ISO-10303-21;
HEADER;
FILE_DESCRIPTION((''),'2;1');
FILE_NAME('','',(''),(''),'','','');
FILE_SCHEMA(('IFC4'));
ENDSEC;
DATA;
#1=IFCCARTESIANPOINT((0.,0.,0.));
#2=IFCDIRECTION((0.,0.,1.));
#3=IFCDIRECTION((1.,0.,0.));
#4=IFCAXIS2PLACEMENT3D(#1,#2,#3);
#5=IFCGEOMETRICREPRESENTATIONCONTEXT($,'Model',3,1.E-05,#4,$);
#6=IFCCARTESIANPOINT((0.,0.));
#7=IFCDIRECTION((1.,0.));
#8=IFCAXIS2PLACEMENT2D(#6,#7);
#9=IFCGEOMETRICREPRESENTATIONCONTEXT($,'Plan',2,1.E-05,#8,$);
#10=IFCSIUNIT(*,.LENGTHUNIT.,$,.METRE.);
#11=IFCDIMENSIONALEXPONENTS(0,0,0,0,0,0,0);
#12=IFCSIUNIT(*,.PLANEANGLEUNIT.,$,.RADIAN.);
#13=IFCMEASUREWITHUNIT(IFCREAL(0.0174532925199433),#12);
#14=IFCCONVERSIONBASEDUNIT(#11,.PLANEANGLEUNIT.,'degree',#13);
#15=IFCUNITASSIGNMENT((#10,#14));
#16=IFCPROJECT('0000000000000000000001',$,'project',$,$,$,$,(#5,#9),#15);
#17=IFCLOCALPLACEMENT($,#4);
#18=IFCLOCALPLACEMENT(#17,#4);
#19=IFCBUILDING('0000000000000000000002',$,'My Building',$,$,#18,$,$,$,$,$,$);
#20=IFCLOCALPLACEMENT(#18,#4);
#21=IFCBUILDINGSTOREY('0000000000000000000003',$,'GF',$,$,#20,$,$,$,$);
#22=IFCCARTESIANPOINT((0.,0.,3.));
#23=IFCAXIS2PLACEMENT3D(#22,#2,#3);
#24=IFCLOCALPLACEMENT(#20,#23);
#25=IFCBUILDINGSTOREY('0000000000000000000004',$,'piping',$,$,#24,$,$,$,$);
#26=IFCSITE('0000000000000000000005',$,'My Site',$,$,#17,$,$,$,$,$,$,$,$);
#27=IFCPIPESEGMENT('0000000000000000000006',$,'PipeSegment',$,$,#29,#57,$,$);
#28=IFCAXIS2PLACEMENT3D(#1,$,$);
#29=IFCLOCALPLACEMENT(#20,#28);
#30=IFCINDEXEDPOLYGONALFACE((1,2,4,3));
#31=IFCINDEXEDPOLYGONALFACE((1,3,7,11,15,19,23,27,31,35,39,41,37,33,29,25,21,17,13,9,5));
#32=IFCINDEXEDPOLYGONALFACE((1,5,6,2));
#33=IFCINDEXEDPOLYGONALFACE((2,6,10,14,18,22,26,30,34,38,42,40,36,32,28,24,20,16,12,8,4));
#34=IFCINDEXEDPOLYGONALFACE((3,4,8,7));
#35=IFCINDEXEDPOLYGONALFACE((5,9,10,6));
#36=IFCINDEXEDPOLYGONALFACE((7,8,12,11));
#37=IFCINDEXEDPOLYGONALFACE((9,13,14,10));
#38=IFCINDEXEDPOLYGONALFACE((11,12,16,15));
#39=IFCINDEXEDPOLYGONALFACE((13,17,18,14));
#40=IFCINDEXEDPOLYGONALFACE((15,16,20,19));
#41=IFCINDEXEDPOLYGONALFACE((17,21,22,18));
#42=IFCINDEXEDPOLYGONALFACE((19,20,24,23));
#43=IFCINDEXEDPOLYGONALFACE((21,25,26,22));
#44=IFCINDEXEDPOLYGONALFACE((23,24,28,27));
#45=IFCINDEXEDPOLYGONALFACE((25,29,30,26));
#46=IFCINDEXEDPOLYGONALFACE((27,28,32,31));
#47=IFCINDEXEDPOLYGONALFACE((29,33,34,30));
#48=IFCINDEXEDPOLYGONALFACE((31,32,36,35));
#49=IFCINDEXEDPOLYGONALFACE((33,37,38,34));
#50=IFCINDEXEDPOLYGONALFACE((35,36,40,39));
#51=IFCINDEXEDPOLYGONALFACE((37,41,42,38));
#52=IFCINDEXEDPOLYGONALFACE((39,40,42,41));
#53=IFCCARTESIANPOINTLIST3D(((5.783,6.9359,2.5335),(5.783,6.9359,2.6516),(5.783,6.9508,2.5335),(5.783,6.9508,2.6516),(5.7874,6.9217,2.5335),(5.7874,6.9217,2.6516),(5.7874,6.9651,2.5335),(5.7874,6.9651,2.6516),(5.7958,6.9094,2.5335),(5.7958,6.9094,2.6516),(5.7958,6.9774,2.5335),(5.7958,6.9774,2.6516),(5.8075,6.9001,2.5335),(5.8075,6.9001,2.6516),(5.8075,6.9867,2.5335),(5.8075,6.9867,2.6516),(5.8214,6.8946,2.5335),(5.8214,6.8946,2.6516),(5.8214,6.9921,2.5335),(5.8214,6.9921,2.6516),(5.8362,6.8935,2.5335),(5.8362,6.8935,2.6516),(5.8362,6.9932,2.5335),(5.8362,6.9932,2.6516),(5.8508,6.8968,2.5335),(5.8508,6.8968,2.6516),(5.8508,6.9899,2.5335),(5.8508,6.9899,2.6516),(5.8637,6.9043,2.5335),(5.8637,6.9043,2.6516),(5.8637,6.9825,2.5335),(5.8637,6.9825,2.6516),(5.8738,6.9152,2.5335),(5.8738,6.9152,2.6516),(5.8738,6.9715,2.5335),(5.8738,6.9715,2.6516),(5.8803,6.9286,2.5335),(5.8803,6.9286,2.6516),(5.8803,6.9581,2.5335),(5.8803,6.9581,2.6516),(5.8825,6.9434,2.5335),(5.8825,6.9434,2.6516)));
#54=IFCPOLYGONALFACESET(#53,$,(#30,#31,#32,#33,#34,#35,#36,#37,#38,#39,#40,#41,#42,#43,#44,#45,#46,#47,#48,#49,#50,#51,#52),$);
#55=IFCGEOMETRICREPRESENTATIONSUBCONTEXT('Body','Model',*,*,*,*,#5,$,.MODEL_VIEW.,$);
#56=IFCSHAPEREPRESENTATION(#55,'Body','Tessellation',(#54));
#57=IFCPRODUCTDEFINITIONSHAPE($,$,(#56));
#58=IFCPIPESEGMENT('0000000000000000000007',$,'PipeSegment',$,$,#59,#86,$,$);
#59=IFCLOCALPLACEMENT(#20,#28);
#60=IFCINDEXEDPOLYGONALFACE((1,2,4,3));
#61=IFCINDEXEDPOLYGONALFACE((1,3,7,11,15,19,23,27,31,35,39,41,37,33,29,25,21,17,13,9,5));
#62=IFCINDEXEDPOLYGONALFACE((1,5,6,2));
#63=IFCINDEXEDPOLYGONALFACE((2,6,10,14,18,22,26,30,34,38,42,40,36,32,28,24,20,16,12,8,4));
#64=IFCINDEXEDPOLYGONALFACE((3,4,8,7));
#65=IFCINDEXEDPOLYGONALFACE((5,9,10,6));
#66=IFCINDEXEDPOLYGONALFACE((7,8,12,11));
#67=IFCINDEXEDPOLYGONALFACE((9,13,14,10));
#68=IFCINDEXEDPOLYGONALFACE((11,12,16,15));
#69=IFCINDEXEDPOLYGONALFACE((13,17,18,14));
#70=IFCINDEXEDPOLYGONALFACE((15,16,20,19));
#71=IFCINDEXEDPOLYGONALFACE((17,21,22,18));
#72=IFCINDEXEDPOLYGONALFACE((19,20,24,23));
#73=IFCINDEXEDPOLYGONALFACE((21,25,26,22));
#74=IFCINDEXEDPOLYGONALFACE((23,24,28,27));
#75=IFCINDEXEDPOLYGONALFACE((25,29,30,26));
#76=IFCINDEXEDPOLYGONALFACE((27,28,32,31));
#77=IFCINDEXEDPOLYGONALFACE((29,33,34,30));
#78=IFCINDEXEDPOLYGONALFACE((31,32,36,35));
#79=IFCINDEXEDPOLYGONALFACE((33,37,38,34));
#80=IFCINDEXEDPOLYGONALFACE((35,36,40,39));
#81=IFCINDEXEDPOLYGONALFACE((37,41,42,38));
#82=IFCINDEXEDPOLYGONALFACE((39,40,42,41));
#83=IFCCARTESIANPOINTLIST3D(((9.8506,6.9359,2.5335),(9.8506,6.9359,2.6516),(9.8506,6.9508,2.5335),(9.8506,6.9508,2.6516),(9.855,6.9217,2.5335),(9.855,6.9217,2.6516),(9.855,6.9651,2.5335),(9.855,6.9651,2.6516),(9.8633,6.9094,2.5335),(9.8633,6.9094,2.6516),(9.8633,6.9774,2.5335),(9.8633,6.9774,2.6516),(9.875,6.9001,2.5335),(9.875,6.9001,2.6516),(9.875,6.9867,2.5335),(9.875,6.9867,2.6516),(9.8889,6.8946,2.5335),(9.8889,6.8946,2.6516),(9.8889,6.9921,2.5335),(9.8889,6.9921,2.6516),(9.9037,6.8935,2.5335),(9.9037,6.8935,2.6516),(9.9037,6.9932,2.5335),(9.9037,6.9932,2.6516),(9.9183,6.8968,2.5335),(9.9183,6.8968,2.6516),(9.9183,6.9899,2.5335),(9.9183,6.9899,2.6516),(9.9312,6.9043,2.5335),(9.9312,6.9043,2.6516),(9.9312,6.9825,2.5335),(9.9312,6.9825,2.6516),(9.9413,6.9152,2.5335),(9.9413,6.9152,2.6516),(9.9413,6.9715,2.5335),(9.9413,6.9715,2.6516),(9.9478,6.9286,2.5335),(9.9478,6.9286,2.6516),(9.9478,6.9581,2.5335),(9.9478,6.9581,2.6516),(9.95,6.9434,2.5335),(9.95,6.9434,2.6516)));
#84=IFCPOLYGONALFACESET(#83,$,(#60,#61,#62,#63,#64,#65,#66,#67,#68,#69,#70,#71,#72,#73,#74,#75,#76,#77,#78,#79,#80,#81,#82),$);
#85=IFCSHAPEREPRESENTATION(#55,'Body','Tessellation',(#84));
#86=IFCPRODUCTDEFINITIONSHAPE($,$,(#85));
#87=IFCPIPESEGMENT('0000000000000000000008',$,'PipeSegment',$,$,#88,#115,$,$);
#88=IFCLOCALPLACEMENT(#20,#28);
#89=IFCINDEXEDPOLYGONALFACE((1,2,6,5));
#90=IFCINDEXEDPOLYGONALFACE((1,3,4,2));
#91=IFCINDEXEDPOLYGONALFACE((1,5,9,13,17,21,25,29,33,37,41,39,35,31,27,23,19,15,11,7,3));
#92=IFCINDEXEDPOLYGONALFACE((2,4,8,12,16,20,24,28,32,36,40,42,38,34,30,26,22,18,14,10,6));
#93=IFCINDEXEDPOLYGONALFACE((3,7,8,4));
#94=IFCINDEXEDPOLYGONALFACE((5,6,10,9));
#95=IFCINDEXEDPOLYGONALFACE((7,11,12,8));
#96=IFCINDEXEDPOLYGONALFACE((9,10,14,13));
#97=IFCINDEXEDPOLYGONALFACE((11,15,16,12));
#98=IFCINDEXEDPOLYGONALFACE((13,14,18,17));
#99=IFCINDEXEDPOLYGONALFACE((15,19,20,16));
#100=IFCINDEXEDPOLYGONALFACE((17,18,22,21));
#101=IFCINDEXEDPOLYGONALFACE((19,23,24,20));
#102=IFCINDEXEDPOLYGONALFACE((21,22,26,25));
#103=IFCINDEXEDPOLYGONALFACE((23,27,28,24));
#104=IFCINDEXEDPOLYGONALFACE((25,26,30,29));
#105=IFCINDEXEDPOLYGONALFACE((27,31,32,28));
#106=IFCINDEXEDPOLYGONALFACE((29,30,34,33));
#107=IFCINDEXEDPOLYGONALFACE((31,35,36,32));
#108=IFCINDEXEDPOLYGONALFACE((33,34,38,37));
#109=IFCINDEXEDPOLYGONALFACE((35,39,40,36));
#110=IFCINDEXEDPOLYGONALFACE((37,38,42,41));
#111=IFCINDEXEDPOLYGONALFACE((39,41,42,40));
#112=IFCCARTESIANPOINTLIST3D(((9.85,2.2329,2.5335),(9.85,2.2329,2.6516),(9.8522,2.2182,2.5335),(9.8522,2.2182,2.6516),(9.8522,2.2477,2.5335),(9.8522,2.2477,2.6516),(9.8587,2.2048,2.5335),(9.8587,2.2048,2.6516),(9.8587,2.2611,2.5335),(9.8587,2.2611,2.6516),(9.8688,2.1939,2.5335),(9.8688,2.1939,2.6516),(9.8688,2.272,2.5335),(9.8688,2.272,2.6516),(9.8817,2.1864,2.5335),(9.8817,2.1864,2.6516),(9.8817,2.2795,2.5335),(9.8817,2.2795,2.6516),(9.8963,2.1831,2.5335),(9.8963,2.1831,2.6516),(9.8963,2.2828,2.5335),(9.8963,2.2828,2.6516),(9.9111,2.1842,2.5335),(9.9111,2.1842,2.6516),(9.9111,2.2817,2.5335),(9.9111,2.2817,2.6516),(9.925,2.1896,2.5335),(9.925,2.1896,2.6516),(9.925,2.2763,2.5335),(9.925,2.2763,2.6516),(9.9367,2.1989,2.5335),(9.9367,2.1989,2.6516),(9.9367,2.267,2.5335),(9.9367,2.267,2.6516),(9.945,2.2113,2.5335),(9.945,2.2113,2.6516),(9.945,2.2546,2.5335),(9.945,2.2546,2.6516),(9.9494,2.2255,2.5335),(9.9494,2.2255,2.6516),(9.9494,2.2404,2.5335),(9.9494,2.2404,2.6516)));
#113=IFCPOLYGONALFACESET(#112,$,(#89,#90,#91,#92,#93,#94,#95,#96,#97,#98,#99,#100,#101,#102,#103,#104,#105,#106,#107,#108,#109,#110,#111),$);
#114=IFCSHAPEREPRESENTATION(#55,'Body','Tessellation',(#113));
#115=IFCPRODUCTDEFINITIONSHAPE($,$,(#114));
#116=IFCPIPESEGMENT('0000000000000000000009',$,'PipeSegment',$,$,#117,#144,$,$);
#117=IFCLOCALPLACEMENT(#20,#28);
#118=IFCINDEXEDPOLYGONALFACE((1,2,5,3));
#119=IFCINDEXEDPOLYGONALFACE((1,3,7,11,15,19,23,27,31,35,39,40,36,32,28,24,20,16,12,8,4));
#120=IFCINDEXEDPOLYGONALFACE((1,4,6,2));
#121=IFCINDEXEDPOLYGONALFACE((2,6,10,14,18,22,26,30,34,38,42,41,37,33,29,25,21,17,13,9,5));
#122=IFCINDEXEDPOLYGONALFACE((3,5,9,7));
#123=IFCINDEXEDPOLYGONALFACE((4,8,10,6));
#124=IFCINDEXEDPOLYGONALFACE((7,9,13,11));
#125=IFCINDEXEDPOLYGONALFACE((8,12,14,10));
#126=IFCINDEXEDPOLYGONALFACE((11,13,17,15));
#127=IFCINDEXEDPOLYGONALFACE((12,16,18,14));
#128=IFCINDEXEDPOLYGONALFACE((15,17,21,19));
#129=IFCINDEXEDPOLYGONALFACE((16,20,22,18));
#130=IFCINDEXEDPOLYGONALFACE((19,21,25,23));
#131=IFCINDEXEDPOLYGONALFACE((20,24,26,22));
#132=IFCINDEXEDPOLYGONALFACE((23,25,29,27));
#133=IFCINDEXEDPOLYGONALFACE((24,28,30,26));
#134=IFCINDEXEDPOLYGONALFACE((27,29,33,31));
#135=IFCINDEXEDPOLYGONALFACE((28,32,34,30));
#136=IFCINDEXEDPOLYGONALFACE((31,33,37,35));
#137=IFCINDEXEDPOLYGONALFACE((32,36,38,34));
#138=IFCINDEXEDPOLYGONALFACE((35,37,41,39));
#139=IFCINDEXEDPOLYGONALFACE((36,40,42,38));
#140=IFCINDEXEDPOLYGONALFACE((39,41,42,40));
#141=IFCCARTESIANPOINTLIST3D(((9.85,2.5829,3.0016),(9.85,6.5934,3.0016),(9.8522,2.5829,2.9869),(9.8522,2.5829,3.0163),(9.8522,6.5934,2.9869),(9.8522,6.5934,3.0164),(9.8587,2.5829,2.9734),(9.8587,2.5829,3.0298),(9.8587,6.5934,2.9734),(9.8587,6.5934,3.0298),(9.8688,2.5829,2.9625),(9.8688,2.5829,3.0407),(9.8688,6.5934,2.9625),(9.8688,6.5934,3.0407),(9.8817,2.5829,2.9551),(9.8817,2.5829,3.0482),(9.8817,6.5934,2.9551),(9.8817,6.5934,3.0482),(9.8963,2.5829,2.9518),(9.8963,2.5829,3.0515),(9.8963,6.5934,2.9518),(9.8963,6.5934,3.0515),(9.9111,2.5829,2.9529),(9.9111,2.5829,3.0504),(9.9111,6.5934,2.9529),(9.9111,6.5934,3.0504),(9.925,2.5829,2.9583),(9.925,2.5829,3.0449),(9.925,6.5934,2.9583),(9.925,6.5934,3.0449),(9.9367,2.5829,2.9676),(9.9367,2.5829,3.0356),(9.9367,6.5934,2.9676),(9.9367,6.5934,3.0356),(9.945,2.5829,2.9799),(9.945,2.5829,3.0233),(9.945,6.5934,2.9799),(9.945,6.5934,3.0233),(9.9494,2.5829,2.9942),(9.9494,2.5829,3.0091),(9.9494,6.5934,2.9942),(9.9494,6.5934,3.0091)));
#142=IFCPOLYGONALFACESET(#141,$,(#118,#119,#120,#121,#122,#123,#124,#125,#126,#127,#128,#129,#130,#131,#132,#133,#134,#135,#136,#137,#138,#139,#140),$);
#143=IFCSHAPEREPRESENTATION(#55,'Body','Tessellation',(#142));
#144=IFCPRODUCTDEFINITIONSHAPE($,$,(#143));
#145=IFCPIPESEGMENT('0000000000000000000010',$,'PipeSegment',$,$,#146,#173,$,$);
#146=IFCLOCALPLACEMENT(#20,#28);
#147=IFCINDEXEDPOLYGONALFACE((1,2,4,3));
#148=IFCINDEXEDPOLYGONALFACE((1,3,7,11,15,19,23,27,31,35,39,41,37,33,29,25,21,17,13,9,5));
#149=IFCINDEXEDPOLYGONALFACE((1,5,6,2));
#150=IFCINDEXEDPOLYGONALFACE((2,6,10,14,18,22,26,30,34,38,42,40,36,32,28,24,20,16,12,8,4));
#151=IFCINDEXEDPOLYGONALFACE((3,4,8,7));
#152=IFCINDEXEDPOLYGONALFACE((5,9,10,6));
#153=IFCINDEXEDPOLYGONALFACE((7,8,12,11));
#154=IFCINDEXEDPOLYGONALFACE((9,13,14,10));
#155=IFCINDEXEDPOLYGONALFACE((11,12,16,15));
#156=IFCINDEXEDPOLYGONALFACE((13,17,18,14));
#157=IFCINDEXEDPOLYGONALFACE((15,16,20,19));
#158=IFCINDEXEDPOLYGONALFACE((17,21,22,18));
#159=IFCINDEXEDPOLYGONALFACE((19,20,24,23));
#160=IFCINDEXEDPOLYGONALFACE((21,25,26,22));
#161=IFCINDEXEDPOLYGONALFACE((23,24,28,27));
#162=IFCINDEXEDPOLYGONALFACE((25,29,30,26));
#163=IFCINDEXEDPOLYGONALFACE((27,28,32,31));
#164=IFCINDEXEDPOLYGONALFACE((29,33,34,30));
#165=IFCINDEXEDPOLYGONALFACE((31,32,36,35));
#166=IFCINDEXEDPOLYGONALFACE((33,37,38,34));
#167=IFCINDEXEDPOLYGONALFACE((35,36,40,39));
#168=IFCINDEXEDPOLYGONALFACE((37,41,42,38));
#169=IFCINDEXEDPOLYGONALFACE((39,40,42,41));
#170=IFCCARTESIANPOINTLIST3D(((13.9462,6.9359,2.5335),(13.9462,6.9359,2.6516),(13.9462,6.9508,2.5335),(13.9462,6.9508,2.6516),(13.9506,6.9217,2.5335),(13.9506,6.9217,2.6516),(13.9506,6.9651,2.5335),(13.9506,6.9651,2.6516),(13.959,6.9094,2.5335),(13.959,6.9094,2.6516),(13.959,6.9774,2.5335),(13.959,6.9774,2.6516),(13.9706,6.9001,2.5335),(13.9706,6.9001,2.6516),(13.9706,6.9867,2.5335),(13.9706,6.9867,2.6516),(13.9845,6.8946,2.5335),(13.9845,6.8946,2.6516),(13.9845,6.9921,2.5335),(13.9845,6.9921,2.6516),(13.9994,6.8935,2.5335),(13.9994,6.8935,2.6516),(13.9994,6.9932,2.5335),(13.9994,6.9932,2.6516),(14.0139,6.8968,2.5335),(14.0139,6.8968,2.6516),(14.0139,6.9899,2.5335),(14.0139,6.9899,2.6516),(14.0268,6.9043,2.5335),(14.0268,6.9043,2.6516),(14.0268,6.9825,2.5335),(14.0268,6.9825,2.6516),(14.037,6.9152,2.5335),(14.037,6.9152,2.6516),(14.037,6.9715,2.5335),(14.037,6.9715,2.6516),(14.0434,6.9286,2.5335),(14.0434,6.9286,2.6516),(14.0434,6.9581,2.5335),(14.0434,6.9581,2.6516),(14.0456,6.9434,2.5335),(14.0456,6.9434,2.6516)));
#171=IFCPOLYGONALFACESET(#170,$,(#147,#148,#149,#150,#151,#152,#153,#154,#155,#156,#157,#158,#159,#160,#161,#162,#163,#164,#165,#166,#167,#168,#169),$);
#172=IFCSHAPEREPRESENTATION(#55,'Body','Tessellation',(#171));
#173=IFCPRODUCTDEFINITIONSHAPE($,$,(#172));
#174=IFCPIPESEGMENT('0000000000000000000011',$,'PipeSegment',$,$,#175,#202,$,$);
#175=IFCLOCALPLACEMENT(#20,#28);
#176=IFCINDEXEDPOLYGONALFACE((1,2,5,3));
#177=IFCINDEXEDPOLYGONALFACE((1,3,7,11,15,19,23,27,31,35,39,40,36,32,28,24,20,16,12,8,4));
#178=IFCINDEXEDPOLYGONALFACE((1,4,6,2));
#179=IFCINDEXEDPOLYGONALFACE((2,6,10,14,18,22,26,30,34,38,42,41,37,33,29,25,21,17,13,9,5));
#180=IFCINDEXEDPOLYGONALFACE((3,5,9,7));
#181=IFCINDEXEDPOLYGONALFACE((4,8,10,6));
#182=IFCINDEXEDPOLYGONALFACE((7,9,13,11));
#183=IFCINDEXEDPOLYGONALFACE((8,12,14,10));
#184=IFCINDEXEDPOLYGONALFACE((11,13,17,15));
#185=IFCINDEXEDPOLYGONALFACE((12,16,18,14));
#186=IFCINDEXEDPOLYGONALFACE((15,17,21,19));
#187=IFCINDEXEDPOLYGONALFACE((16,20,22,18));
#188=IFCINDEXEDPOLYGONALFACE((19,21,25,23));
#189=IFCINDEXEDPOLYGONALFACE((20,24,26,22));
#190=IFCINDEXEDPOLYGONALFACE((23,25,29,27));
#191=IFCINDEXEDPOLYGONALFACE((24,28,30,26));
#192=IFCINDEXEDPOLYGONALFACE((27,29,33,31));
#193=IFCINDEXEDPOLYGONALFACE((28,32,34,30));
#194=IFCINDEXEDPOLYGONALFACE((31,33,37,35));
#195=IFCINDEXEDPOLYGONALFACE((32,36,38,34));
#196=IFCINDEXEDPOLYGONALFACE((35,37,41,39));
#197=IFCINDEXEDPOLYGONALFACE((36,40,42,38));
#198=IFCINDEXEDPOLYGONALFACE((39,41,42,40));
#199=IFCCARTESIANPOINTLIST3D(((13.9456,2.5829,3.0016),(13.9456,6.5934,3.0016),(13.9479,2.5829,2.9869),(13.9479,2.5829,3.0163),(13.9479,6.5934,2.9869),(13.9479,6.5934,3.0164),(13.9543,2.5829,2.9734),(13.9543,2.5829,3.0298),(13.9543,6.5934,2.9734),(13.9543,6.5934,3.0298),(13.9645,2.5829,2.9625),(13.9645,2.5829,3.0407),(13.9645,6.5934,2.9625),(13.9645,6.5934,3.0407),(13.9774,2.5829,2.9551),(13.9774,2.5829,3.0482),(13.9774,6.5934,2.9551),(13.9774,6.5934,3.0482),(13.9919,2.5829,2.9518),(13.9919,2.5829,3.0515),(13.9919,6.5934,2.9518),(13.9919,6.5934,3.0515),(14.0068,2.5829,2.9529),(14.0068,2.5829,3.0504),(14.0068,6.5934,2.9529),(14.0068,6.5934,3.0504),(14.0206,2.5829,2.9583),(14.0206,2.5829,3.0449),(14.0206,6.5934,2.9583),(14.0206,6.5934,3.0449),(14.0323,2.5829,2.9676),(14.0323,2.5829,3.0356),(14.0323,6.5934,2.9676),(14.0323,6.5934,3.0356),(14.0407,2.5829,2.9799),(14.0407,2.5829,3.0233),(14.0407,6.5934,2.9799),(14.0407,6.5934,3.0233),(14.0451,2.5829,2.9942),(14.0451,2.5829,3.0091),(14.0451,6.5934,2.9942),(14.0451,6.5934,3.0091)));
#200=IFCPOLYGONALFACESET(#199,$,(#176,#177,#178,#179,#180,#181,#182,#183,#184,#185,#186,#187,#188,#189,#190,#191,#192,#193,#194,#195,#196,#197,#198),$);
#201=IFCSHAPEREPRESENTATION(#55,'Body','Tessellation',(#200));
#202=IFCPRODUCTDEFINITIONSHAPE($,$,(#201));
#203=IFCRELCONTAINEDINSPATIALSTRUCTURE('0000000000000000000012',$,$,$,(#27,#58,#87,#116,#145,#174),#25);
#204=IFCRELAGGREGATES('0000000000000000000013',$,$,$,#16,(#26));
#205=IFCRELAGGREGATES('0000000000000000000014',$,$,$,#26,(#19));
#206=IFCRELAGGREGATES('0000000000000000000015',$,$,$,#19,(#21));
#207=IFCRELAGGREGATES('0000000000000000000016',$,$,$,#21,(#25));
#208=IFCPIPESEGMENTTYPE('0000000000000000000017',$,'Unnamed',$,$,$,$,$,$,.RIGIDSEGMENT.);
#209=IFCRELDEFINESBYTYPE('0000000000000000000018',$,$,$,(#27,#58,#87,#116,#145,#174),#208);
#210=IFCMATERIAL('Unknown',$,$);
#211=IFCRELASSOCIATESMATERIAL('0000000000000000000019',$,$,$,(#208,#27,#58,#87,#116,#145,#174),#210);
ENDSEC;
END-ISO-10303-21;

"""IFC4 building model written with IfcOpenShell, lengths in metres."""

from ifc_helpers import new_model, entity, si_unit, converted_unit, frame, origin_with_axes, origin_2d_with_axis, place, context, subcontext, project, spatial, circle, extrude, material, material_profile, profile_set, profile_usage, type_object, element, save


model = new_model("IFC4")

# Units and contexts
model_context = context("Model", 3, precision=1e-05, world=origin_with_axes())
plan_context = context("Plan", 2, precision=1e-05, world=origin_2d_with_axis())
body_context = subcontext(model_context, "Body", "Model", "MODEL_VIEW")
ifc_project = project(units=[si_unit("LENGTHUNIT", "METRE"), converted_unit("PLANEANGLEUNIT", "degree", entity("IfcReal", 0.0174532925199433), si_unit("PLANEANGLEUNIT", "RADIAN"), dimensions=[0, 0, 0, 0, 0, 0, 0])], contexts=[model_context, plan_context])

# Site, building, storeys
site_placement = place(None, origin_with_axes())
site = spatial("IfcSite", under=ifc_project, at=site_placement, Name="My Site")
building_placement = place(site_placement, origin_with_axes())
building = spatial("IfcBuilding", under=site, at=building_placement, Name="My Building")
storey_1_placement = place(building_placement, origin_with_axes())
storey_1 = spatial("IfcBuildingStorey", under=building, at=storey_1_placement, Name="GF")
storey_2_placement = place(storey_1_placement, frame((0.0, 0.0, 3.0), z_axis=(0.0, 0.0, 1.0), x_axis=(1.0, 0.0, 0.0)))
storey_2 = spatial("IfcBuildingStorey", under=storey_1, at=storey_2_placement, Name="piping")

# Pipe segments
ifc_material = material(Name="Unknown")
ifc_material_profile = material_profile(ifc_material, circle(Radius=0.05))
ifc_profile_set = profile_set([ifc_material_profile])
pipe_segment_type = type_object("IfcPipeSegmentType", Name="Unnamed", PredefinedType="RIGIDSEGMENT", material=ifc_profile_set)
ifc_profile_usage_1 = profile_usage(ifc_profile_set, cardinal=5)
pipe_segment_1_placement = place(storey_2_placement, frame((5.8325, 6.9434, -0.3484), z_axis=(0.0, 0.0, -1.0), x_axis=(1.0, 0.0, 0.0)))
element("IfcPipeSegment", 1, at=pipe_segment_1_placement, inside=storey_2, type_object=pipe_segment_type, material=ifc_profile_usage_1, Name="PipeSegment", context=body_context, shape_type="SweptSolid", body=[
    extrude(circle(Radius=0.05), origin_with_axes(), (0.0, 0.0, 1.0), 0.1181),
])
ifc_profile_usage_2 = profile_usage(ifc_profile_set, cardinal=5)
pipe_segment_2_placement = place(storey_2_placement, frame((9.9, 6.9434, -0.3484), z_axis=(0.0, 0.0, -1.0), x_axis=(1.0, 0.0, 0.0)))
element("IfcPipeSegment", 2, at=pipe_segment_2_placement, inside=storey_2, type_object=pipe_segment_type, material=ifc_profile_usage_2, Name="PipeSegment", context=body_context, shape_type="SweptSolid", body=[
    extrude(circle(Radius=0.05), origin_with_axes(), (0.0, 0.0, 1.0), 0.1181),
])
ifc_profile_usage_3 = profile_usage(ifc_profile_set, cardinal=5)
pipe_segment_3_placement = place(storey_2_placement, frame((9.9, 2.2329, -0.3484), z_axis=(0.0, 0.0, -1.0), x_axis=(-1.0, 0.0, 0.0)))
element("IfcPipeSegment", 3, at=pipe_segment_3_placement, inside=storey_2, type_object=pipe_segment_type, material=ifc_profile_usage_3, Name="PipeSegment", context=body_context, shape_type="SweptSolid", body=[
    extrude(circle(Radius=0.05), origin_with_axes(), (0.0, 0.0, 1.0), 0.1181),
])
ifc_profile_usage_4 = profile_usage(ifc_profile_set, cardinal=5)
pipe_segment_4_placement = place(storey_2_placement, frame((9.9, 2.5829, 0.0016), z_axis=(0.0, 1.0, 0.0), x_axis=(-1.0, 0.0, 0.0)))
element("IfcPipeSegment", 4, at=pipe_segment_4_placement, inside=storey_2, type_object=pipe_segment_type, material=ifc_profile_usage_4, Name="PipeSegment", context=body_context, shape_type="SweptSolid", body=[
    extrude(circle(Radius=0.05), origin_with_axes(), (0.0, 0.0, 1.0), 4.0104),
])
ifc_profile_usage_5 = profile_usage(ifc_profile_set, cardinal=5)
pipe_segment_5_placement = place(storey_2_placement, frame((13.9956, 6.9434, -0.3484), z_axis=(0.0, 0.0, -1.0), x_axis=(1.0, 0.0, 0.0)))
element("IfcPipeSegment", 5, at=pipe_segment_5_placement, inside=storey_2, type_object=pipe_segment_type, material=ifc_profile_usage_5, Name="PipeSegment", context=body_context, shape_type="SweptSolid", body=[
    extrude(circle(Radius=0.05), origin_with_axes(), (0.0, 0.0, 1.0), 0.1181),
])
ifc_profile_usage_6 = profile_usage(ifc_profile_set, cardinal=5)
pipe_segment_6_placement = place(storey_2_placement, frame((13.9956, 2.5829, 0.0016), z_axis=(0.0, 1.0, 0.0), x_axis=(-1.0, 0.0, 0.0)))
element("IfcPipeSegment", 6, at=pipe_segment_6_placement, inside=storey_2, type_object=pipe_segment_type, material=ifc_profile_usage_6, Name="PipeSegment", context=body_context, shape_type="SweptSolid", body=[
    extrude(circle(Radius=0.05), origin_with_axes(), (0.0, 0.0, 1.0), 4.0104),
])

save(model, "model.ifc")
